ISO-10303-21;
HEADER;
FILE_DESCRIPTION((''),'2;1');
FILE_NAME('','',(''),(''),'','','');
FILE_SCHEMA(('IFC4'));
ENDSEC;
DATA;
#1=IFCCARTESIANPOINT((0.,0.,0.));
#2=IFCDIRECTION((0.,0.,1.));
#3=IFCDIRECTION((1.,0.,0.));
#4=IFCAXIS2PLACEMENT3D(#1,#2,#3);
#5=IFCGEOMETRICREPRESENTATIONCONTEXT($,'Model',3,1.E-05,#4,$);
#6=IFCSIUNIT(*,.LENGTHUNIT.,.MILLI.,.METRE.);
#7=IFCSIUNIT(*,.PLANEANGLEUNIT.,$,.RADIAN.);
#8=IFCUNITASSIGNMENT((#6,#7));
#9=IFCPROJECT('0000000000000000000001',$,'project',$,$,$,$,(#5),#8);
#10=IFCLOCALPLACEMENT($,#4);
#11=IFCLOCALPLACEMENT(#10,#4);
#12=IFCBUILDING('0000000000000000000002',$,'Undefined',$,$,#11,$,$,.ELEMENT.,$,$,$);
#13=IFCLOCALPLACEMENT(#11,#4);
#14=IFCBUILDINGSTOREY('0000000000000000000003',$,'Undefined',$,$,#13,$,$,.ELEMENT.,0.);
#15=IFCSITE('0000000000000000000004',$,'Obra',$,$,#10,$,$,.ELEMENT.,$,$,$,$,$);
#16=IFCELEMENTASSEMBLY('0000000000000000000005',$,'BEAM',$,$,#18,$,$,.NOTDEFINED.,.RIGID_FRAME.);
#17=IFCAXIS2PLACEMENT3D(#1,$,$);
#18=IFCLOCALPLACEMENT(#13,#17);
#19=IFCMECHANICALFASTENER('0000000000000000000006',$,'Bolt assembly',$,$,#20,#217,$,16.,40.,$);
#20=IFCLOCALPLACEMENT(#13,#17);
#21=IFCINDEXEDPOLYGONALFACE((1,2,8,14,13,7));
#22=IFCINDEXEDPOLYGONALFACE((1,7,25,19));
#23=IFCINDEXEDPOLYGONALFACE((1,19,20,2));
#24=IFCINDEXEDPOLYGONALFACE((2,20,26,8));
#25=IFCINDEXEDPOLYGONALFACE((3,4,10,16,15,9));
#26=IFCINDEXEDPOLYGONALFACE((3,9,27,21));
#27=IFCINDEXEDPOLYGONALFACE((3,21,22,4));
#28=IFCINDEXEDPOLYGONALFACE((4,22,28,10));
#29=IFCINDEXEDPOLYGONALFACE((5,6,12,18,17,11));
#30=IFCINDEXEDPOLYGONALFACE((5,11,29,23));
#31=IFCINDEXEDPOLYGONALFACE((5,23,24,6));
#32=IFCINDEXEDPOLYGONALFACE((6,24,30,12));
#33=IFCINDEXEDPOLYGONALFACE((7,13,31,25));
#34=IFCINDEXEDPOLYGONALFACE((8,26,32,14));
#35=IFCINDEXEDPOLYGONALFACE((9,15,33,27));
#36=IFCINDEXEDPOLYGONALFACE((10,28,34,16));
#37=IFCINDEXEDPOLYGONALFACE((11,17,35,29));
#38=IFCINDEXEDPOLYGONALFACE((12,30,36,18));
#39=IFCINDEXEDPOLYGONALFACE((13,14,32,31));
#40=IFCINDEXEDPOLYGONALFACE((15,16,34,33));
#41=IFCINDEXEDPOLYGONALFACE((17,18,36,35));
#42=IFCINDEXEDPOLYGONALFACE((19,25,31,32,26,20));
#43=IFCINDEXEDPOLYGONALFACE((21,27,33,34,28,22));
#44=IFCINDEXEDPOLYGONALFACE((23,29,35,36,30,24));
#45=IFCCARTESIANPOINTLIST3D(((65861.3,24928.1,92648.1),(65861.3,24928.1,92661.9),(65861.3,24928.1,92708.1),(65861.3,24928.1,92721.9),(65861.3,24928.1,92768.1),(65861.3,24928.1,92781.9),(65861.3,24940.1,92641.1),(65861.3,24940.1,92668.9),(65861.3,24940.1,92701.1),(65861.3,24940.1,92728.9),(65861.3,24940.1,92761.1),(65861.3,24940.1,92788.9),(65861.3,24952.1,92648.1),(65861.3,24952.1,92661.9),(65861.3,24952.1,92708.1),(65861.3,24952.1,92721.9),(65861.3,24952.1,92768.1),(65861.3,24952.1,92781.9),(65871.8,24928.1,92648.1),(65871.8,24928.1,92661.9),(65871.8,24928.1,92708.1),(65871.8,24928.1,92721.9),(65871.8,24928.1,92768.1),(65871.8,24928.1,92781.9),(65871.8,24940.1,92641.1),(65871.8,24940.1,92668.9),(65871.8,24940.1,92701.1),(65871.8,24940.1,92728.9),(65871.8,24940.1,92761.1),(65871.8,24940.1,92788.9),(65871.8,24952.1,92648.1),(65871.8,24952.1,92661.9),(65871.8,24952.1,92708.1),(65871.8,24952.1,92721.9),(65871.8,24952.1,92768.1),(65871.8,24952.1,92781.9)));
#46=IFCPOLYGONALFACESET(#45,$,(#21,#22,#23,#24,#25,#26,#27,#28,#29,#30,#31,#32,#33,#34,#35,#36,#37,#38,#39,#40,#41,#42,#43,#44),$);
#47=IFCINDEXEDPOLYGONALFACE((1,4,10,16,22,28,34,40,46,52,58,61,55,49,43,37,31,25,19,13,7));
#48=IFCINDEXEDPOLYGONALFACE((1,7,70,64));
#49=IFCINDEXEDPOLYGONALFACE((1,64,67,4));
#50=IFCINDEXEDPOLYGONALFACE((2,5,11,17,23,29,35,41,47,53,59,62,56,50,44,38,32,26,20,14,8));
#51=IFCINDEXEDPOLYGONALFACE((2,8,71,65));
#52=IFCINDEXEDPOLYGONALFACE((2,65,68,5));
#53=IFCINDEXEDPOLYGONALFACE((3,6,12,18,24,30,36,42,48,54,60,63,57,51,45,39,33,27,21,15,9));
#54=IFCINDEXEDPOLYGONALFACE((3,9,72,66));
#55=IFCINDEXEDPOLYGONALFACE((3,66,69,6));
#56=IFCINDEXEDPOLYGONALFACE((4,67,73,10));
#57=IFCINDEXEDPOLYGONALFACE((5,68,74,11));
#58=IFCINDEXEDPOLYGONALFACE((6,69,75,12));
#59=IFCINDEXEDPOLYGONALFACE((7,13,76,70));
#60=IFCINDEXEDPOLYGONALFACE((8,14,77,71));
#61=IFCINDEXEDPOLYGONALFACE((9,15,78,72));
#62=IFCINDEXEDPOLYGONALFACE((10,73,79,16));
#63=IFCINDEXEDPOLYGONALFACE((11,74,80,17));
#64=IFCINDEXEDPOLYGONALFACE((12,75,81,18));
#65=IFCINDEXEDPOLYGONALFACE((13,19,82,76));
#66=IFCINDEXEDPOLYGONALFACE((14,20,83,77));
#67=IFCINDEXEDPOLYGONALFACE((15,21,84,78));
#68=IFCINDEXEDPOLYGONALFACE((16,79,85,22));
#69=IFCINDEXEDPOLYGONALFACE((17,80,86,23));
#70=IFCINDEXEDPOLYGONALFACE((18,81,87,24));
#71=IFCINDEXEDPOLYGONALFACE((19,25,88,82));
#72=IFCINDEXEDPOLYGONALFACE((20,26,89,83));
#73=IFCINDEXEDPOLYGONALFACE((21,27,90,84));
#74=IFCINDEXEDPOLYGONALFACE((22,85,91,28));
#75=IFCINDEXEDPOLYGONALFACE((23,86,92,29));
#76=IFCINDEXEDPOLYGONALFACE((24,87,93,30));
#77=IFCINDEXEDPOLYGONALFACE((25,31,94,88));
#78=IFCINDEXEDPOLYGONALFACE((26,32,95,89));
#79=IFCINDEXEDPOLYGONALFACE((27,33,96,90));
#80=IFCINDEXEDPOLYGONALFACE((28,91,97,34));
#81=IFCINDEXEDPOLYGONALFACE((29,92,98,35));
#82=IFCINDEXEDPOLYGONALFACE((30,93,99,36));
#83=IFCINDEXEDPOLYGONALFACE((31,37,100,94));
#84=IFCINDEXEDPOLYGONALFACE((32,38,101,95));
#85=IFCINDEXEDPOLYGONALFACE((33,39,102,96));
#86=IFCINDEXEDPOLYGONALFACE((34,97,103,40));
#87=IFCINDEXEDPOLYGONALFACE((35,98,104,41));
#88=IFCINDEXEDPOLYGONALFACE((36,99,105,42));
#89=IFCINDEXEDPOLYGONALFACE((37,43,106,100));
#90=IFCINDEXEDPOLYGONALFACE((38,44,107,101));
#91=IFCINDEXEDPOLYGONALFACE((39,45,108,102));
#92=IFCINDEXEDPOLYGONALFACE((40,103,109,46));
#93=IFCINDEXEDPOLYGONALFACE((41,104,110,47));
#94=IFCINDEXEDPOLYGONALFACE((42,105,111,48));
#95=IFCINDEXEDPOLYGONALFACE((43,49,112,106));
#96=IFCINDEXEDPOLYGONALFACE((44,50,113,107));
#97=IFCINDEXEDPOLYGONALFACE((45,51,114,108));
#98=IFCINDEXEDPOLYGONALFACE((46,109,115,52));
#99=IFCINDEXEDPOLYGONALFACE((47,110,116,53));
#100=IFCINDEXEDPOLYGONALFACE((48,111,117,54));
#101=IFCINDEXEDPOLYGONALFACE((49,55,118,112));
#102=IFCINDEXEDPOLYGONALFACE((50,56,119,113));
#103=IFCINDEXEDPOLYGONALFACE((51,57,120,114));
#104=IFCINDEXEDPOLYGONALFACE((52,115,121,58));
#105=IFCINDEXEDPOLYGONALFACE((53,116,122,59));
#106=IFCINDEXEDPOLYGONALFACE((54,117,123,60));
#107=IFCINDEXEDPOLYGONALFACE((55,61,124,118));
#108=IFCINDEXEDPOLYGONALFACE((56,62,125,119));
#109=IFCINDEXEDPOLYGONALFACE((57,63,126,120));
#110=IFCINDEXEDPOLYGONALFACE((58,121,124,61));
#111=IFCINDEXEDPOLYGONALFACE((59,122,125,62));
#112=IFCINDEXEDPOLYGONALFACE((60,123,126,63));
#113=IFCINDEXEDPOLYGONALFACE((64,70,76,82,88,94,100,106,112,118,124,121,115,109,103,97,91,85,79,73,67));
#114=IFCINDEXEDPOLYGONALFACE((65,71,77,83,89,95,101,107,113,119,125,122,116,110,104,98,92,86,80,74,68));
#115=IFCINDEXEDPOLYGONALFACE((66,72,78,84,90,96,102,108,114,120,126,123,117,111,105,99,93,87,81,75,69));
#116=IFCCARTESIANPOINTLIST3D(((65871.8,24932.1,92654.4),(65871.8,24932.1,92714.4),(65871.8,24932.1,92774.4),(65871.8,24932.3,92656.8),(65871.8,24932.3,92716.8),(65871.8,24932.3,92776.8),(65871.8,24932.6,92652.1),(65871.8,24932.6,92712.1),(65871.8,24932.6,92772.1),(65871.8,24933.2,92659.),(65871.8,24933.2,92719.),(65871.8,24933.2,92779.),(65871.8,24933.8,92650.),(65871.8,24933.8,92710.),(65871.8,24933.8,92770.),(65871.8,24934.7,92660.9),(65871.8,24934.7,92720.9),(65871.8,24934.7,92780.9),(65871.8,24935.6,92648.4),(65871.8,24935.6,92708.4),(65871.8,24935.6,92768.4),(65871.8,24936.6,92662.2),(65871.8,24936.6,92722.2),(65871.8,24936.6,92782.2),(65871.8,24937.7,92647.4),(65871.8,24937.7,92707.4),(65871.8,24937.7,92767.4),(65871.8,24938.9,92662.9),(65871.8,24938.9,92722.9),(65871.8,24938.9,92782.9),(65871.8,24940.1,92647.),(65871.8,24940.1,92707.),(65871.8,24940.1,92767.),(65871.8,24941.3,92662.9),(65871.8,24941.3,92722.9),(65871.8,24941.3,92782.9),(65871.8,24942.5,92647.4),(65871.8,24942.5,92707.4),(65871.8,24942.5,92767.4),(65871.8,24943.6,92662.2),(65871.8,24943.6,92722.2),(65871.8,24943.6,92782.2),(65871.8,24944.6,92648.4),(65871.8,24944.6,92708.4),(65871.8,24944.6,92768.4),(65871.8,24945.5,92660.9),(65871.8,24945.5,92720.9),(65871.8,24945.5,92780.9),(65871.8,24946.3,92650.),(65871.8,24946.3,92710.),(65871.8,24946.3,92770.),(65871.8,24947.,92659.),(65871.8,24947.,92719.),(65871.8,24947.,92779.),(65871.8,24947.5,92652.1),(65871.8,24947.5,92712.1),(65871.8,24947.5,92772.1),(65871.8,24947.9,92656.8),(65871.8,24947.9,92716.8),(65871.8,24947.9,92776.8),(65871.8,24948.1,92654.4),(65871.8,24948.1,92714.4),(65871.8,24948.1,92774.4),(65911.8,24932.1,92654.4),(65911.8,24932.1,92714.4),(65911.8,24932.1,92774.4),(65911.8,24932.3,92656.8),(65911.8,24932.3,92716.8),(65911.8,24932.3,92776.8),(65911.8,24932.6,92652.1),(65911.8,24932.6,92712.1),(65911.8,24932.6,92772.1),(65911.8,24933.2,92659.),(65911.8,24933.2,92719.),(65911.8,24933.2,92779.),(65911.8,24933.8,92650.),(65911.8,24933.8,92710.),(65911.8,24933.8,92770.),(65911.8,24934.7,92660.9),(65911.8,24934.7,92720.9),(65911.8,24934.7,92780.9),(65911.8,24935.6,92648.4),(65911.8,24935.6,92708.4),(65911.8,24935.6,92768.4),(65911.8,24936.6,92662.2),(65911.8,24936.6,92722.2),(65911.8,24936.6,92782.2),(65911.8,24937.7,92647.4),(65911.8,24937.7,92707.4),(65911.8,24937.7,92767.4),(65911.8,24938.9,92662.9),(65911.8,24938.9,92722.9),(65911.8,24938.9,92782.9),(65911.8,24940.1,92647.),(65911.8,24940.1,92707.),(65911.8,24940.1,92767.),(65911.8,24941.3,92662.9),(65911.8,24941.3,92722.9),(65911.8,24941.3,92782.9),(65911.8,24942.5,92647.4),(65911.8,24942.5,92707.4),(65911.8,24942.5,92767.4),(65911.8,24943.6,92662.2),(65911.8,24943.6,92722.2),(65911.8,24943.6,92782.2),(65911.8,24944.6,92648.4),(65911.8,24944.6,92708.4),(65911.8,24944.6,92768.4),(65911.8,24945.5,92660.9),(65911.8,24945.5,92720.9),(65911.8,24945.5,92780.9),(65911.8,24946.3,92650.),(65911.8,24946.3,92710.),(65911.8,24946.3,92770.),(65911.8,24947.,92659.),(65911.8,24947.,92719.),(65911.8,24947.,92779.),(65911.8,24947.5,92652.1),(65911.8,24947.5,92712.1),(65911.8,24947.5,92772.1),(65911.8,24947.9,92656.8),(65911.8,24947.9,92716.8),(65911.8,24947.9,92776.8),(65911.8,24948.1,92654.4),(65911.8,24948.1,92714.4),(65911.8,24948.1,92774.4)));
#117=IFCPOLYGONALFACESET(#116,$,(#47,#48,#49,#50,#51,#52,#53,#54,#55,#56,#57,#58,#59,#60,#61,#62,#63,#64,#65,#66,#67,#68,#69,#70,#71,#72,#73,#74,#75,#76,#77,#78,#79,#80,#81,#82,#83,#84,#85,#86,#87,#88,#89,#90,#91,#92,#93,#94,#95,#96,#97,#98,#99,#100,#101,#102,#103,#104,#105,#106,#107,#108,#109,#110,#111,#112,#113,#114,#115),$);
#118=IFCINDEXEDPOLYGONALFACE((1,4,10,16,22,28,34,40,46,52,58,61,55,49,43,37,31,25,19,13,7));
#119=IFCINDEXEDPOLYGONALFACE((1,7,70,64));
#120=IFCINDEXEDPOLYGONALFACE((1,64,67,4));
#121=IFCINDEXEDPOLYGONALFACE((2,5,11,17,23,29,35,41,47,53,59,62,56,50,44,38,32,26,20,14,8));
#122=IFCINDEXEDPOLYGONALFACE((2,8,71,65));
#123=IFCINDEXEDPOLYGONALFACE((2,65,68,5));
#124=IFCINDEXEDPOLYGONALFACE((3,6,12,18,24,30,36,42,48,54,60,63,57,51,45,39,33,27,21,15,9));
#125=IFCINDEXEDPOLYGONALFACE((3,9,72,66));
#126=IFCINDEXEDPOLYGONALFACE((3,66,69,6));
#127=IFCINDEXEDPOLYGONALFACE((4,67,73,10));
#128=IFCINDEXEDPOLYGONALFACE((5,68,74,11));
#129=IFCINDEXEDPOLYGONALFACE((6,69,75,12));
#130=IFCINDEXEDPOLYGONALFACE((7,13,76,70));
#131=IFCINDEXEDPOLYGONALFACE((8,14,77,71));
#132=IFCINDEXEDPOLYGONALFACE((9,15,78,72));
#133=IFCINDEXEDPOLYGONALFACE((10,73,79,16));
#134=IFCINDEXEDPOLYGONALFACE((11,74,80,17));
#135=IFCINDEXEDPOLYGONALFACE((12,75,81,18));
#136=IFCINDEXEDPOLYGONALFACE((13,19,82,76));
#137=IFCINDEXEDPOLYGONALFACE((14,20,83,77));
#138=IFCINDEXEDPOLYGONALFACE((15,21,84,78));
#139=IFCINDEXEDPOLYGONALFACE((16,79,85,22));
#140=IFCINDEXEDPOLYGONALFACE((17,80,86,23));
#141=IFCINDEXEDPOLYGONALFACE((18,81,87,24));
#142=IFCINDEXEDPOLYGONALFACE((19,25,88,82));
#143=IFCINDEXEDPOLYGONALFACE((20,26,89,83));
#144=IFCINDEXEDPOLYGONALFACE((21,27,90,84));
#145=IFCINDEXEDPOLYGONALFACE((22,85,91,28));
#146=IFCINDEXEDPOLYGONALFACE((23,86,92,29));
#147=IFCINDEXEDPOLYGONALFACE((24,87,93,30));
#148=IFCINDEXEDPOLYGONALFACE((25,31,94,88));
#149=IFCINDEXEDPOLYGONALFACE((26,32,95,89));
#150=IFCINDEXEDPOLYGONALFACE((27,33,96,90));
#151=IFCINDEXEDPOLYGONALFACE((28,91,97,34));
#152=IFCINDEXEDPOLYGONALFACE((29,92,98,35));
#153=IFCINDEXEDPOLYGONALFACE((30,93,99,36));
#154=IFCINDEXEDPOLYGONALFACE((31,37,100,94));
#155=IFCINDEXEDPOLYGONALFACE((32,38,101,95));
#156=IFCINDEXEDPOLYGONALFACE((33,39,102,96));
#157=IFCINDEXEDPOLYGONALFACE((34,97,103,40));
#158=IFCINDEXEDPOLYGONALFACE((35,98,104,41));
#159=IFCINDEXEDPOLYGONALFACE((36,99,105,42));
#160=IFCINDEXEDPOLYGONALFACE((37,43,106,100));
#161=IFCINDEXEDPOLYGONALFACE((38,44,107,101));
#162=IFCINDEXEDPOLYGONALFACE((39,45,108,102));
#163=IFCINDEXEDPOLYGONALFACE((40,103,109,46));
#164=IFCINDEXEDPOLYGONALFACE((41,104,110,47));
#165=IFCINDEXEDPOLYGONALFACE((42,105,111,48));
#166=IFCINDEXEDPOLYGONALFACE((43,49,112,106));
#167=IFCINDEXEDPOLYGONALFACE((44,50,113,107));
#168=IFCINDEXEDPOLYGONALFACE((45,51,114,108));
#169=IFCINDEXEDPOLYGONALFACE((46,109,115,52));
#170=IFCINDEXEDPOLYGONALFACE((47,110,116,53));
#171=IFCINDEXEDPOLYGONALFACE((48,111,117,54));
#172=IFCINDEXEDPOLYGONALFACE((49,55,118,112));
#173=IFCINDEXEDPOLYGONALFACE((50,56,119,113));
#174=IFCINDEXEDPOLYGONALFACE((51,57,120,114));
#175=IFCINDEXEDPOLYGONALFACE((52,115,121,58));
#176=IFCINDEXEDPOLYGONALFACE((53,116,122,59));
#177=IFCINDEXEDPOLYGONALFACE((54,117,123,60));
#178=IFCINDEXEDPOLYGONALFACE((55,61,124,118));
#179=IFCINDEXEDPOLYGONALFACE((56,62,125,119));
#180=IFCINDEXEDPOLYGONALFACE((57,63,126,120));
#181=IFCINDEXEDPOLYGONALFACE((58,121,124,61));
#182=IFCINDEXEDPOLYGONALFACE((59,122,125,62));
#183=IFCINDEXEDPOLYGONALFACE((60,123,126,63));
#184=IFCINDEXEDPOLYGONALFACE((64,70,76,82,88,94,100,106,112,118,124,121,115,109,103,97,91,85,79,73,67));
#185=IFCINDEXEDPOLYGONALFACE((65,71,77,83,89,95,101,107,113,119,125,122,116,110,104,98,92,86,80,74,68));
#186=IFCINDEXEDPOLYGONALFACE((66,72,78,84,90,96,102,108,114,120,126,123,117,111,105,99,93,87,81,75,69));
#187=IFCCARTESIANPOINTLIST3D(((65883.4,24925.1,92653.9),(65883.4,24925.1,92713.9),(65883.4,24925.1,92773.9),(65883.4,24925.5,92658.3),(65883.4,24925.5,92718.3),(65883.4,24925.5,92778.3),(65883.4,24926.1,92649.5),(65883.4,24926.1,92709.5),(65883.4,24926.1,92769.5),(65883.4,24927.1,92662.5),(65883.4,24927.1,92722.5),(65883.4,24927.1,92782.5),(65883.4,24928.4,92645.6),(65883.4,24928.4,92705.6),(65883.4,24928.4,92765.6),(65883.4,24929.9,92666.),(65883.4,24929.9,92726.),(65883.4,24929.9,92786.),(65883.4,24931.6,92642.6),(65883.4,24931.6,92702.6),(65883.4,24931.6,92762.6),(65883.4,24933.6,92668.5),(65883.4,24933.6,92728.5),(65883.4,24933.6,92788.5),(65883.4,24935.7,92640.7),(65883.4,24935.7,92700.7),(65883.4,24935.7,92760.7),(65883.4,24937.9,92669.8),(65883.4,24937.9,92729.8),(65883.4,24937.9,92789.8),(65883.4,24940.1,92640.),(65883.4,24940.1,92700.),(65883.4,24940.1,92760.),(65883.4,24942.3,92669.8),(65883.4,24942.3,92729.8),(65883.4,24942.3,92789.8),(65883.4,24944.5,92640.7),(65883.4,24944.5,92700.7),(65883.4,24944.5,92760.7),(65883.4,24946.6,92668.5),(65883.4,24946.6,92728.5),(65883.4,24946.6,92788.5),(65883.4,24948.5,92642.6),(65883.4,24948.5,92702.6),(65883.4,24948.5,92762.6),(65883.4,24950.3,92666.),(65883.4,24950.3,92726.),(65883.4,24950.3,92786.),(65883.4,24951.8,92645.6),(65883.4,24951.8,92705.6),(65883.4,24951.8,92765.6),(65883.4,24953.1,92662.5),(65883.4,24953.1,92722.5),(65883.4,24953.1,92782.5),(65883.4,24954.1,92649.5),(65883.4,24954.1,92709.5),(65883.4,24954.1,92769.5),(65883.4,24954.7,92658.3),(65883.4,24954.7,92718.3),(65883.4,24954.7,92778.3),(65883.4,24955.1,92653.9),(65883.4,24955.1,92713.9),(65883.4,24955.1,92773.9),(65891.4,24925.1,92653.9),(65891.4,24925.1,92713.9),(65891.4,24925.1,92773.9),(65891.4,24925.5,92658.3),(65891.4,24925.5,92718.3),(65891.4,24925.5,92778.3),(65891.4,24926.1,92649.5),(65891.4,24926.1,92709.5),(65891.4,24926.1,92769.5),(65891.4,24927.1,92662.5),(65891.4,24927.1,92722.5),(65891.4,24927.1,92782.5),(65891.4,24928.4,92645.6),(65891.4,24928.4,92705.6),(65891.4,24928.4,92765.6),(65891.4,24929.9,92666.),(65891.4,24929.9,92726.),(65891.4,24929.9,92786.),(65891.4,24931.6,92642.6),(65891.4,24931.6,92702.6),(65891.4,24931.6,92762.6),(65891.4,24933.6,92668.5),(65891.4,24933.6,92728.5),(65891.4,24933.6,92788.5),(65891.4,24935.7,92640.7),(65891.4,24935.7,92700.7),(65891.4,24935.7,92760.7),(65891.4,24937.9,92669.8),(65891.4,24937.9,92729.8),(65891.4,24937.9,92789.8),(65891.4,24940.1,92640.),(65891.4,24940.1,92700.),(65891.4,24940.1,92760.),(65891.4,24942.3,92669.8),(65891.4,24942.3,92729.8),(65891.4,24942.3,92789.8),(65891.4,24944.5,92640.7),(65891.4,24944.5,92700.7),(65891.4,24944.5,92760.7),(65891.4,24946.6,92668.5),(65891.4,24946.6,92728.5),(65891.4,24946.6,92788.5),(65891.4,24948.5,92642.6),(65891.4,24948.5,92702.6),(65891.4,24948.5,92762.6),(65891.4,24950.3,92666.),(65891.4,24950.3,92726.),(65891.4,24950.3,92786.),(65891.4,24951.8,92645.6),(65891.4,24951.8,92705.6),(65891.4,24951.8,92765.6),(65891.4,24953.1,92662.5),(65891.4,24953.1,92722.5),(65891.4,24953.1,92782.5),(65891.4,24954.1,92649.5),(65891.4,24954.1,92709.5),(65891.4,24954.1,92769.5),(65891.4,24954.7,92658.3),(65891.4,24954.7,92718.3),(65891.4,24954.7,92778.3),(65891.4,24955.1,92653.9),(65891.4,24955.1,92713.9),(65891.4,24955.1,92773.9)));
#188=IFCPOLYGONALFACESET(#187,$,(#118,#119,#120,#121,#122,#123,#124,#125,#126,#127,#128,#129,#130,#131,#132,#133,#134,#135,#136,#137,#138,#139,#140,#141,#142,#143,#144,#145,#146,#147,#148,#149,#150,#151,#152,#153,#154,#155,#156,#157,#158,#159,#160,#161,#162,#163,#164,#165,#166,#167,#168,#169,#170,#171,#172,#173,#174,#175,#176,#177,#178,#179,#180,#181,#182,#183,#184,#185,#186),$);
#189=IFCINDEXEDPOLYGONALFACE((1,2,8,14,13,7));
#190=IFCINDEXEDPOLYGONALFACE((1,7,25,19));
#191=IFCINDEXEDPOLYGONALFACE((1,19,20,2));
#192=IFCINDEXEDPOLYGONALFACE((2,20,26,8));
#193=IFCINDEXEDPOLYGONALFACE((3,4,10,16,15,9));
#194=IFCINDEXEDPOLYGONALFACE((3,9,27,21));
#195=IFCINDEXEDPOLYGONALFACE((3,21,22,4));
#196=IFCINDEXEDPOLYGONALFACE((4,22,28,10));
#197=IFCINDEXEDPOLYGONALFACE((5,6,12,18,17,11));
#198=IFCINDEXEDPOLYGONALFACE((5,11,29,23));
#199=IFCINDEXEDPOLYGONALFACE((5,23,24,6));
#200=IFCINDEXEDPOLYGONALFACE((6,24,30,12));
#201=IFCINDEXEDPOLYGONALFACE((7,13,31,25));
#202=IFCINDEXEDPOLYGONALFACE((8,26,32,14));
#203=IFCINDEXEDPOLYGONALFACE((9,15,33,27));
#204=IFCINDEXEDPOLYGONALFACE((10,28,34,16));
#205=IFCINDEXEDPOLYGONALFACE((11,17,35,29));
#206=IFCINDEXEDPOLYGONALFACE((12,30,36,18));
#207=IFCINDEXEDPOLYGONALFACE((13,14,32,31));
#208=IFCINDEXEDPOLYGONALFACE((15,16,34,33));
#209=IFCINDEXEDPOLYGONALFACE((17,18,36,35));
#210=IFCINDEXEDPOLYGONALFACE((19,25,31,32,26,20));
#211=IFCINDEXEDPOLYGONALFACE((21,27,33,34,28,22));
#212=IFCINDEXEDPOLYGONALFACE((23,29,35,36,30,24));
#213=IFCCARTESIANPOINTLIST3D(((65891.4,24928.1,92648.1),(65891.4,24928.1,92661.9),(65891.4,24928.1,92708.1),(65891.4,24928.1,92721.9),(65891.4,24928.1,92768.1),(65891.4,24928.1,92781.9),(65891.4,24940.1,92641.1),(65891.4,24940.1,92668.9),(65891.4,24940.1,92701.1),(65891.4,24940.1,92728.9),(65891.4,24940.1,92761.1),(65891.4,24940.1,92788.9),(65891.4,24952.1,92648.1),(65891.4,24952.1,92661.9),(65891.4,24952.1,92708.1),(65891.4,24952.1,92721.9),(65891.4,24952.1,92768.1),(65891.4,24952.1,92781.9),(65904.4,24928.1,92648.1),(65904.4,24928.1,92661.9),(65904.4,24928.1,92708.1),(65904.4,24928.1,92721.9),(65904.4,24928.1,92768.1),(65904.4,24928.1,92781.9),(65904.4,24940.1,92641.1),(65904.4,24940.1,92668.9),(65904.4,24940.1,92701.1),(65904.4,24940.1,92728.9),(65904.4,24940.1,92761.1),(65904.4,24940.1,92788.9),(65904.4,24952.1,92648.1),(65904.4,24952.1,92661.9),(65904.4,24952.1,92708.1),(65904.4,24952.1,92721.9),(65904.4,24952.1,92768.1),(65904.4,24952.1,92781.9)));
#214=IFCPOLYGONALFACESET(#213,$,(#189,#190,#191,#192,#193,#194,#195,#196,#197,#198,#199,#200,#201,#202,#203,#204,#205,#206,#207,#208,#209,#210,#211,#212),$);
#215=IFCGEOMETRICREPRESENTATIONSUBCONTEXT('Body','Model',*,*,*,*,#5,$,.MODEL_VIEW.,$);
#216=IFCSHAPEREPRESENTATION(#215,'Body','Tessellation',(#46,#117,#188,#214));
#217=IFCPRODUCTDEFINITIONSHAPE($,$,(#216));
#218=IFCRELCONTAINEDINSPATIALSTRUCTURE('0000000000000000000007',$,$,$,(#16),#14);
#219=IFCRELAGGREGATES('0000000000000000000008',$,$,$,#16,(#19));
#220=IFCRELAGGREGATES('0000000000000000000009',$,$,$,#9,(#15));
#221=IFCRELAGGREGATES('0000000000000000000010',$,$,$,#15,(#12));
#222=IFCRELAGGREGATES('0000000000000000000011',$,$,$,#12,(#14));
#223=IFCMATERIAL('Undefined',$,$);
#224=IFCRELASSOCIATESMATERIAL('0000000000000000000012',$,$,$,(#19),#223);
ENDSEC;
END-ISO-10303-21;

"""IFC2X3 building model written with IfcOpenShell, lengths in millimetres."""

from ifc_helpers import new_model, si_unit, frame, origin_with_axes, origin_2d_with_axis, place, context, subcontext, project, spatial, polyline, circle, outline, extrude, source, transform, mapped, material, element, aggregate, save


model = new_model("IFC2X3")

# Units and contexts
model_context = context("Model", 3, precision=1e-05, world=origin_with_axes())
body_context = subcontext(model_context, "Body", "Model", "MODEL_VIEW")
ifc_project = project(units=[si_unit("LENGTHUNIT", "METRE", prefix="MILLI"), si_unit("PLANEANGLEUNIT", "RADIAN")], contexts=[model_context])

# Site, building, storey
site_placement = place(None, origin_with_axes())
site = spatial("IfcSite", under=ifc_project, at=site_placement, Name="Obra", CompositionType="ELEMENT")
building_placement = place(site_placement, origin_with_axes())
building = spatial("IfcBuilding", under=site, at=building_placement, Name="Undefined", CompositionType="ELEMENT")
storey_placement = place(building_placement, origin_with_axes())
storey = spatial("IfcBuildingStorey", under=building, at=storey_placement, Name="Undefined", CompositionType="ELEMENT", Elevation=0.0)

# Shared definitions
ifc_material_1 = material(Name="Undefined")

# Element assembly, mechanical fastener
assembly_1_placement = place(storey_placement, origin_with_axes())
assembly_1 = element("IfcElementAssembly", 1, at=assembly_1_placement, inside=storey, Name="BEAM", AssemblyPlace="NOTDEFINED", PredefinedType="RIGID_FRAME")
shared_shape_1 = source(origin_with_axes(), body_context, "Body", "SweptSolid", [
    extrude(outline(polyline([(13.9, 0.0), (6.9, 12.0), (-6.9, 12.0), (-13.9, 0.0), (-6.9, -12.0), (6.9, -12.0), (13.9, 0.0)])), frame((0.0, -19.7, 0.0), z_axis=(0.0, 1.0, 0.0), x_axis=(1.0, 0.0, 0.0)), (0.0, 0.0, 1.0), 10.6),
    extrude(circle(Radius=8.0, at=origin_2d_with_axis()), frame((0.0, -9.1, 0.0), z_axis=(0.0, 1.0, 0.0), x_axis=(1.0, 0.0, 0.0)), (0.0, 0.0, 1.0), 40.0),
    extrude(circle(Radius=15.0, at=origin_2d_with_axis()), frame((0.0, 2.5, 0.0), z_axis=(0.0, 1.0, 0.0), x_axis=(1.0, 0.0, 0.0)), (0.0, 0.0, 1.0), 8.0),
    extrude(outline(polyline([(13.9, 0.0), (6.9, 12.0), (-6.9, 12.0), (-13.9, 0.0), (-6.9, -12.0), (6.9, -12.0), (13.9, 0.0)])), frame((0.0, 10.5, 0.0), z_axis=(0.0, 1.0, 0.0), x_axis=(1.0, 0.0, 0.0)), (0.0, 0.0, 1.0), 13.0),
])
mechanical_fastener_1_placement = place(assembly_1_placement, frame((65880.9, 24990.1, 92835.0), z_axis=(0.000002, -1.0, 0.0), x_axis=(0.0, 0.0, -1.0)))
mechanical_fastener_1 = element("IfcMechanicalFastener", 2, at=mechanical_fastener_1_placement, material=ifc_material_1, Name="Bolt assembly", NominalDiameter=16.0, NominalLength=40.0, context=body_context, shape_type="MappedRepresentation", body=[
    mapped(shared_shape_1, transform((60.0, 0.0, 50.0))),
    mapped(shared_shape_1, transform((120.0, 0.0, 50.0))),
    mapped(shared_shape_1, transform((180.0, 0.0, 50.0))),
])
aggregate(assembly_1, [mechanical_fastener_1])

save(model, "model.ifc")
